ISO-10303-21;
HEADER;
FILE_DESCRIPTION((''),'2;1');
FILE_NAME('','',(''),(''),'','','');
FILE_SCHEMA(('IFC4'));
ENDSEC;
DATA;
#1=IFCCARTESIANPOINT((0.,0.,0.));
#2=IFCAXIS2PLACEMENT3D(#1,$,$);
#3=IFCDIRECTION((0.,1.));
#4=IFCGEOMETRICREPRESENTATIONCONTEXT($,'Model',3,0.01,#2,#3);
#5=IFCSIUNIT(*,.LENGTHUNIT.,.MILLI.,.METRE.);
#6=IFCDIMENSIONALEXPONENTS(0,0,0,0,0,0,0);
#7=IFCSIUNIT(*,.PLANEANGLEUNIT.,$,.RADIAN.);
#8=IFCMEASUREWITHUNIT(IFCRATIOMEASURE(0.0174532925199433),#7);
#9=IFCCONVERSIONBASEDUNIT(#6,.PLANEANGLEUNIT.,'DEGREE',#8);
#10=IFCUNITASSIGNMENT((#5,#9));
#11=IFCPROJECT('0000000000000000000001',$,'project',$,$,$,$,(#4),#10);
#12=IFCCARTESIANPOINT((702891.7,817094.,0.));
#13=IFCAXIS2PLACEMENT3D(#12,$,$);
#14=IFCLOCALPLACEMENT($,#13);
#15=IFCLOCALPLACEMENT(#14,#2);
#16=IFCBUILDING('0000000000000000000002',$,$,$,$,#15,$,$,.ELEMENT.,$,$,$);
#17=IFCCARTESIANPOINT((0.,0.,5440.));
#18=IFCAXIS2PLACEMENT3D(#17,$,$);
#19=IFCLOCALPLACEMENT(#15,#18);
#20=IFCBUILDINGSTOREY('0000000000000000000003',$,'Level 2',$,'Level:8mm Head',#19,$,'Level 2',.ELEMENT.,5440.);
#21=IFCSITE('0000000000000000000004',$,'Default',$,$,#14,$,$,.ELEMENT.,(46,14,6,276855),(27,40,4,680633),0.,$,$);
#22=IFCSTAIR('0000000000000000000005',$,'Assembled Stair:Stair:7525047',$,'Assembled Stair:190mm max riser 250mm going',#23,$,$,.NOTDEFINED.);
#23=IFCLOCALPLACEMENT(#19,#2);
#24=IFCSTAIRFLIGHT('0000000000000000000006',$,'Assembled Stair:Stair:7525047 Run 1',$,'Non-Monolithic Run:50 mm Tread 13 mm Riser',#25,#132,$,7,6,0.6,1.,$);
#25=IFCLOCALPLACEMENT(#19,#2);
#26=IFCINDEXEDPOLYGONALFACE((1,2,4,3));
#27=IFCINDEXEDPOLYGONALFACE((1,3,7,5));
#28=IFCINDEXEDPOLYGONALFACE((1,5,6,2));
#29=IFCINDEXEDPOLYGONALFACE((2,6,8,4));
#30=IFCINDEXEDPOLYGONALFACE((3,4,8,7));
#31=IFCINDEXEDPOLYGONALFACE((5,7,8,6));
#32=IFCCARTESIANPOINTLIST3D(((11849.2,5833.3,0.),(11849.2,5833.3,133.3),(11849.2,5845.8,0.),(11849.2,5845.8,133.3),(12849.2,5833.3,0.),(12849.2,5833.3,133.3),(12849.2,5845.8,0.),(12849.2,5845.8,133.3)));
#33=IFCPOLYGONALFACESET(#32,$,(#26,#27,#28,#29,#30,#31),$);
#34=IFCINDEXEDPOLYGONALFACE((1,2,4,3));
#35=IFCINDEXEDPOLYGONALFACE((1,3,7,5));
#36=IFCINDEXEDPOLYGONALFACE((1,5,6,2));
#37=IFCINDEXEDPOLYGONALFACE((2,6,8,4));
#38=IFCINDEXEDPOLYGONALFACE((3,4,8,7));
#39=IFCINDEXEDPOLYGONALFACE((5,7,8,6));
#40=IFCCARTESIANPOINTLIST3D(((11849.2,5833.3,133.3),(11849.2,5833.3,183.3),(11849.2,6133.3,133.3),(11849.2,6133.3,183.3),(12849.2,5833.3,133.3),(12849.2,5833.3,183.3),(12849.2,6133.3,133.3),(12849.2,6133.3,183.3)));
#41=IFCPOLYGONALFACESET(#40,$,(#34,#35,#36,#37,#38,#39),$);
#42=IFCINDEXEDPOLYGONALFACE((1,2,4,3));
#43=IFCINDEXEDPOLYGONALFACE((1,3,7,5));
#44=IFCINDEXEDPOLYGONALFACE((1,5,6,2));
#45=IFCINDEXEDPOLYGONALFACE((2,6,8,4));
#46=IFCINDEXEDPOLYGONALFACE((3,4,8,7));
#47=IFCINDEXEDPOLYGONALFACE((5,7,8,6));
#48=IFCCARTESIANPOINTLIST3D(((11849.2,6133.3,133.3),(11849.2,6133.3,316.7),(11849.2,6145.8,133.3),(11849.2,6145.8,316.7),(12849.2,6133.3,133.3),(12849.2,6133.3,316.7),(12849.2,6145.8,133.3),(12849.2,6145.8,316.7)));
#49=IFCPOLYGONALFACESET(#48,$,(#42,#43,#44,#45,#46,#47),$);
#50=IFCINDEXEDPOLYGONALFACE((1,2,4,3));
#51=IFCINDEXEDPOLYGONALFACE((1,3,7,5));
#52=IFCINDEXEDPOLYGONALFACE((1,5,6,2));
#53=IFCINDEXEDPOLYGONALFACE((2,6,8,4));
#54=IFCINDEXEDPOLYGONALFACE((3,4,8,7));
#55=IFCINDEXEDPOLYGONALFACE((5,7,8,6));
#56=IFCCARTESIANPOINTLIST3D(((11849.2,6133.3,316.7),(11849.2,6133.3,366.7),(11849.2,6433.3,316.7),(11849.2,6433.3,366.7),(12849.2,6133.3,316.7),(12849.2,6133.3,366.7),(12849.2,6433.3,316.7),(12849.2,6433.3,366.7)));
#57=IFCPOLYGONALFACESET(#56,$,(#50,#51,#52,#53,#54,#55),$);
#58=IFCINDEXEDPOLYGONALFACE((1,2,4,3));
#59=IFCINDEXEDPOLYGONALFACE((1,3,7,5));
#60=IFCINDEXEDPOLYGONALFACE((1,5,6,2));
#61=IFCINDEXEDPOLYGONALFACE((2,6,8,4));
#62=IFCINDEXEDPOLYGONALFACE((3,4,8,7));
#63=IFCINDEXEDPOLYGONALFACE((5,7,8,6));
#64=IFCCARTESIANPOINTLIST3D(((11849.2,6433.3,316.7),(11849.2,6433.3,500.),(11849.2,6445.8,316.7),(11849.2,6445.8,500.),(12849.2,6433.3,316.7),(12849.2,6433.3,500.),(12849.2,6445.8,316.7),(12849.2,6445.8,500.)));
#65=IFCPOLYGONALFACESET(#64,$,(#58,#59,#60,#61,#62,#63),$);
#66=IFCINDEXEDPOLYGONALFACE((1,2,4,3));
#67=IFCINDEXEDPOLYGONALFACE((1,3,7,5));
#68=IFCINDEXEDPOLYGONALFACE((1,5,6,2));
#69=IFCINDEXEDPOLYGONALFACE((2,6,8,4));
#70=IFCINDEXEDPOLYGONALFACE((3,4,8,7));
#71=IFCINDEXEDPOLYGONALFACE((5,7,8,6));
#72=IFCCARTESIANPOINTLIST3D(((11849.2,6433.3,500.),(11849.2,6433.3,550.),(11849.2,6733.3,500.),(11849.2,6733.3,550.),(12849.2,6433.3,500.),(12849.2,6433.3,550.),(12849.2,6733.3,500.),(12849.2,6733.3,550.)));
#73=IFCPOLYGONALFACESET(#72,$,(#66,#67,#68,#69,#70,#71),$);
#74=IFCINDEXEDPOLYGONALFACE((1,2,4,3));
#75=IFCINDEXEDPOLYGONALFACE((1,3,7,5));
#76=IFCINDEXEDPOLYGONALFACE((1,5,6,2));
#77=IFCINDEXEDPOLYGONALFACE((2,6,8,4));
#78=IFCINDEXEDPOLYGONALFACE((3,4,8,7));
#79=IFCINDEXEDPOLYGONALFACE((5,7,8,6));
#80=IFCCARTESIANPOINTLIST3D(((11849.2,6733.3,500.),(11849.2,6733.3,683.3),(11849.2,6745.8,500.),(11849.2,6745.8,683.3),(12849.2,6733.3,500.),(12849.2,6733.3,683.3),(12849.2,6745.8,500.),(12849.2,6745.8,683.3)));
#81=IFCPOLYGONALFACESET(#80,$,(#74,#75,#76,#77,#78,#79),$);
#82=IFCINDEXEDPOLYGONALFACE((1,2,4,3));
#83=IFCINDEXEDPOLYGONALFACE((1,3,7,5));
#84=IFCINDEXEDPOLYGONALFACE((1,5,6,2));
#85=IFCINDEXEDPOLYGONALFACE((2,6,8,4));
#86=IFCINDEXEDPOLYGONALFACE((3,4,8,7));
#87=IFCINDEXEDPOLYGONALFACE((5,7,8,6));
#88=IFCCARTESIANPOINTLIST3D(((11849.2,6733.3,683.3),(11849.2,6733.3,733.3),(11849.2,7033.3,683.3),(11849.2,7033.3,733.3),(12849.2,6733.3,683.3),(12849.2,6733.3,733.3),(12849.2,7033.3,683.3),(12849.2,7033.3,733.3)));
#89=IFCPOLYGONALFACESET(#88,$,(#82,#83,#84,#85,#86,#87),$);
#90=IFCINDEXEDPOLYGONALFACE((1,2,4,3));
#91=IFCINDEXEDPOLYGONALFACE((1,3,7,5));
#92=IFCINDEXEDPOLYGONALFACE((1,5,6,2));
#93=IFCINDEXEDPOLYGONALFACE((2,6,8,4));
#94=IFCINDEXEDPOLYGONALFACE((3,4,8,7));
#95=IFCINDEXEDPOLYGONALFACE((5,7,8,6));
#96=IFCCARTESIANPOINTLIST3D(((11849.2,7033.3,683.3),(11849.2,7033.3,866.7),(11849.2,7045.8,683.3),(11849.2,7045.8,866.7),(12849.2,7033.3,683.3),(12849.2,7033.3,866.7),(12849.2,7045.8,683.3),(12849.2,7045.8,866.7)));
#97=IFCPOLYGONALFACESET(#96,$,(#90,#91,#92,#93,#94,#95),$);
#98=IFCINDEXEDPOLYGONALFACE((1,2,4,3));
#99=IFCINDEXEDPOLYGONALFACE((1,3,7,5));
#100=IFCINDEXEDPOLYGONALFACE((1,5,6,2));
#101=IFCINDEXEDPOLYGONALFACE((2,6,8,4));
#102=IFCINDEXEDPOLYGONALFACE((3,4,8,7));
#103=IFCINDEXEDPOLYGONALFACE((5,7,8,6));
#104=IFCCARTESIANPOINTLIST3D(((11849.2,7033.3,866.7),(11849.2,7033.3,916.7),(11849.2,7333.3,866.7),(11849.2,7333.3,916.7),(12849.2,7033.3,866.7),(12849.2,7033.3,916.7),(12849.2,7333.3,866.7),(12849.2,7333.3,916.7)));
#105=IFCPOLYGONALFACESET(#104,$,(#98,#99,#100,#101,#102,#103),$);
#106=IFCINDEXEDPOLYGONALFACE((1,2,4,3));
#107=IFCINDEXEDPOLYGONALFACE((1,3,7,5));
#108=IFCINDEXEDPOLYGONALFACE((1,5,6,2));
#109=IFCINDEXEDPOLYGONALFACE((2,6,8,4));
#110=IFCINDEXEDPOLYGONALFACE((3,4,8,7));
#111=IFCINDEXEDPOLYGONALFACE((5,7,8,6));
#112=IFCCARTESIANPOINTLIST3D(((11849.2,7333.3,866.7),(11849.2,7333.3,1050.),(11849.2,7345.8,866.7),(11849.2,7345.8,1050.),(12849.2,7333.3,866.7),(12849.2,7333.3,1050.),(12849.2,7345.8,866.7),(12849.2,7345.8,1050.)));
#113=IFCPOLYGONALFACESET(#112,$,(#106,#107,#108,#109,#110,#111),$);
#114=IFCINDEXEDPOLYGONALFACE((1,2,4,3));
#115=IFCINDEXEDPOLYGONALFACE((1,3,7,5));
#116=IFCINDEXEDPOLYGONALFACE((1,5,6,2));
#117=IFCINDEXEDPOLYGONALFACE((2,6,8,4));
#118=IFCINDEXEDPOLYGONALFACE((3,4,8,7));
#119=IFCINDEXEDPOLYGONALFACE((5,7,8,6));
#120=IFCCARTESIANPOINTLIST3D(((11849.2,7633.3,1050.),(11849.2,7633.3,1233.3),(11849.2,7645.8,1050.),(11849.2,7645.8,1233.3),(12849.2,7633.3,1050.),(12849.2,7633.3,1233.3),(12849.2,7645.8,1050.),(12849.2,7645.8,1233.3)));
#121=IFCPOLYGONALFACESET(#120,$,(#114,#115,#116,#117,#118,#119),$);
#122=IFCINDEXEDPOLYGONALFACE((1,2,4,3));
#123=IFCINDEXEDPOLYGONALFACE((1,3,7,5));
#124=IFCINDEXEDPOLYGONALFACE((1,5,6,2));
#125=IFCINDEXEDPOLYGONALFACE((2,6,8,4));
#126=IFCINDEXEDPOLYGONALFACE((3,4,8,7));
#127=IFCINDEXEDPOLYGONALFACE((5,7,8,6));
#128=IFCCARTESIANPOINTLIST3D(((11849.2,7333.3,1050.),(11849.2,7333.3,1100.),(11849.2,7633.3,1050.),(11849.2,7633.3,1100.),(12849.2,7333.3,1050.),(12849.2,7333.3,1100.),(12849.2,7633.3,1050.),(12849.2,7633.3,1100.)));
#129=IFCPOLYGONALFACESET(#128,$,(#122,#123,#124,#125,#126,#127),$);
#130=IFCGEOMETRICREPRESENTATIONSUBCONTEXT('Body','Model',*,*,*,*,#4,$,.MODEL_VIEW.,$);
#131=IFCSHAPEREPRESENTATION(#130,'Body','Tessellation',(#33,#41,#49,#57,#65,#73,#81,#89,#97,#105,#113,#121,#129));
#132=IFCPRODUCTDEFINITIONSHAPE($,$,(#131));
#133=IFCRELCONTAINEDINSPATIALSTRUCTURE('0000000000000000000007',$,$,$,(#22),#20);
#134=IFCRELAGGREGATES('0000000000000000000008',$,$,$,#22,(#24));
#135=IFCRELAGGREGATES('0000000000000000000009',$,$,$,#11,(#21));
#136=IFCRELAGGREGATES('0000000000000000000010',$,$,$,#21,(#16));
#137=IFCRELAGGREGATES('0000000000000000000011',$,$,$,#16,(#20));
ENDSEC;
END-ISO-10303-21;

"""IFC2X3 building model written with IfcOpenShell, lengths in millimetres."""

from ifc_helpers import new_model, entity, si_unit, converted_unit, direction, frame, frame_2d, origin, place, context, subcontext, project, spatial, rectangle, extrude, element, aggregate, save


model = new_model("IFC2X3")

# Units and contexts
model_context = context("Model", 3, precision=0.01, world=origin(), true_north=direction((0.0, 1.0)))
body_context = subcontext(model_context, "Body", "Model", "MODEL_VIEW")
ifc_project = project(units=[si_unit("LENGTHUNIT", "METRE", prefix="MILLI"), converted_unit("PLANEANGLEUNIT", "DEGREE", entity("IfcRatioMeasure", 0.0174532925199433), si_unit("PLANEANGLEUNIT", "RADIAN"), dimensions=[0, 0, 0, 0, 0, 0, 0])], contexts=[model_context])

# Site, building, storey
site_placement = place(None, frame((702891.7, 817094.0, 0.0)))
site = spatial("IfcSite", under=ifc_project, at=site_placement, Name="Default", CompositionType="ELEMENT", RefLatitude=(46, 14, 6, 276855), RefLongitude=(27, 40, 4, 680633), RefElevation=0.0)
building_placement = place(site_placement, origin())
building = spatial("IfcBuilding", under=site, at=building_placement, CompositionType="ELEMENT")
storey_placement = place(building_placement, frame((0.0, 0.0, 5440.0)))
storey = spatial("IfcBuildingStorey", under=building, at=storey_placement, Name="Level 2", ObjectType="Level:8mm Head", LongName="Level 2", CompositionType="ELEMENT", Elevation=5440.0)

# Stair
stair_1_placement = place(storey_placement, origin())
stair_1 = element("IfcStair", 1, at=stair_1_placement, inside=storey, Name="Assembled Stair:Stair:7525047", ObjectType="Assembled Stair:190mm max riser 250mm going", ShapeType="NOTDEFINED")

# Stair flight
stair_flight_1_placement = place(stair_1_placement, origin())
stair_flight_1 = element("IfcStairFlight", 2, at=stair_flight_1_placement, Name="Assembled Stair:Stair:7525047 Run 1", ObjectType="Non-Monolithic Run:50 mm Tread 13 mm Riser", NumberOfRiser=7, NumberOfTreads=6, RiserHeight=0.6, TreadLength=1.0, context=body_context, shape_type="SweptSolid", body=[
    extrude(rectangle(XDim=1000.0, YDim=12.5, at=frame_2d((0.0, 0.0), x_axis=(1.0, 0.0))), frame((12349.2, 5839.6, 0.0), z_axis=(0.0, 0.0, 1.0), x_axis=(-1.0, 0.0, 0.0)), (0.0, 0.0, 1.0), 133.3),
    extrude(rectangle(XDim=300.0, YDim=1000.0, at=frame_2d((0.0, 0.0), x_axis=(1.0, 0.0))), frame((12349.2, 5983.3, 133.3), z_axis=(0.0, 0.0, 1.0), x_axis=(0.0, -1.0, 0.0)), (0.0, 0.0, 1.0), 50.0),
    extrude(rectangle(XDim=1000.0, YDim=12.5, at=frame_2d((0.0, 0.0), x_axis=(1.0, 0.0))), frame((12349.2, 6139.6, 133.3), z_axis=(0.0, 0.0, 1.0), x_axis=(-1.0, 0.0, 0.0)), (0.0, 0.0, 1.0), 183.3),
    extrude(rectangle(XDim=300.0, YDim=1000.0, at=frame_2d((0.0, 0.0), x_axis=(1.0, 0.0))), frame((12349.2, 6283.3, 316.7), z_axis=(0.0, 0.0, 1.0), x_axis=(0.0, -1.0, 0.0)), (0.0, 0.0, 1.0), 50.0),
    extrude(rectangle(XDim=1000.0, YDim=12.5, at=frame_2d((0.0, 0.0), x_axis=(1.0, 0.0))), frame((12349.2, 6439.6, 316.7), z_axis=(0.0, 0.0, 1.0), x_axis=(-1.0, 0.0, 0.0)), (0.0, 0.0, 1.0), 183.3),
    extrude(rectangle(XDim=300.0, YDim=1000.0, at=frame_2d((0.0, 0.0), x_axis=(1.0, 0.0))), frame((12349.2, 6583.3, 500.0), z_axis=(0.0, 0.0, 1.0), x_axis=(0.0, -1.0, 0.0)), (0.0, 0.0, 1.0), 50.0),
    extrude(rectangle(XDim=1000.0, YDim=12.5, at=frame_2d((0.0, 0.0), x_axis=(1.0, 0.0))), frame((12349.2, 6739.6, 500.0), z_axis=(0.0, 0.0, 1.0), x_axis=(-1.0, 0.0, 0.0)), (0.0, 0.0, 1.0), 183.3),
    extrude(rectangle(XDim=300.0, YDim=1000.0, at=frame_2d((0.0, 0.0), x_axis=(1.0, 0.0))), frame((12349.2, 6883.3, 683.3), z_axis=(0.0, 0.0, 1.0), x_axis=(0.0, -1.0, 0.0)), (0.0, 0.0, 1.0), 50.0),
    extrude(rectangle(XDim=1000.0, YDim=12.5, at=frame_2d((0.0, 0.0), x_axis=(1.0, 0.0))), frame((12349.2, 7039.6, 683.3), z_axis=(0.0, 0.0, 1.0), x_axis=(-1.0, 0.0, 0.0)), (0.0, 0.0, 1.0), 183.3),
    extrude(rectangle(XDim=300.0, YDim=1000.0, at=frame_2d((0.0, 0.0), x_axis=(1.0, 0.0))), frame((12349.2, 7183.3, 866.7), z_axis=(0.0, 0.0, 1.0), x_axis=(0.0, -1.0, 0.0)), (0.0, 0.0, 1.0), 50.0),
    extrude(rectangle(XDim=1000.0, YDim=12.5, at=frame_2d((0.0, 0.0), x_axis=(1.0, 0.0))), frame((12349.2, 7339.6, 866.7), z_axis=(0.0, 0.0, 1.0), x_axis=(-1.0, 0.0, 0.0)), (0.0, 0.0, 1.0), 183.3),
    extrude(rectangle(XDim=1000.0, YDim=12.5, at=frame_2d((0.0, 0.0), x_axis=(1.0, 0.0))), frame((12349.2, 7639.6, 1050.0), z_axis=(0.0, 0.0, 1.0), x_axis=(-1.0, 0.0, 0.0)), (0.0, 0.0, 1.0), 183.3),
    extrude(rectangle(XDim=300.0, YDim=1000.0, at=frame_2d((0.0, 0.0), x_axis=(1.0, 0.0))), frame((12349.2, 7483.3, 1050.0), z_axis=(0.0, 0.0, 1.0), x_axis=(0.0, -1.0, 0.0)), (0.0, 0.0, 1.0), 50.0),
])
aggregate(stair_1, [stair_flight_1])

save(model, "model.ifc")
